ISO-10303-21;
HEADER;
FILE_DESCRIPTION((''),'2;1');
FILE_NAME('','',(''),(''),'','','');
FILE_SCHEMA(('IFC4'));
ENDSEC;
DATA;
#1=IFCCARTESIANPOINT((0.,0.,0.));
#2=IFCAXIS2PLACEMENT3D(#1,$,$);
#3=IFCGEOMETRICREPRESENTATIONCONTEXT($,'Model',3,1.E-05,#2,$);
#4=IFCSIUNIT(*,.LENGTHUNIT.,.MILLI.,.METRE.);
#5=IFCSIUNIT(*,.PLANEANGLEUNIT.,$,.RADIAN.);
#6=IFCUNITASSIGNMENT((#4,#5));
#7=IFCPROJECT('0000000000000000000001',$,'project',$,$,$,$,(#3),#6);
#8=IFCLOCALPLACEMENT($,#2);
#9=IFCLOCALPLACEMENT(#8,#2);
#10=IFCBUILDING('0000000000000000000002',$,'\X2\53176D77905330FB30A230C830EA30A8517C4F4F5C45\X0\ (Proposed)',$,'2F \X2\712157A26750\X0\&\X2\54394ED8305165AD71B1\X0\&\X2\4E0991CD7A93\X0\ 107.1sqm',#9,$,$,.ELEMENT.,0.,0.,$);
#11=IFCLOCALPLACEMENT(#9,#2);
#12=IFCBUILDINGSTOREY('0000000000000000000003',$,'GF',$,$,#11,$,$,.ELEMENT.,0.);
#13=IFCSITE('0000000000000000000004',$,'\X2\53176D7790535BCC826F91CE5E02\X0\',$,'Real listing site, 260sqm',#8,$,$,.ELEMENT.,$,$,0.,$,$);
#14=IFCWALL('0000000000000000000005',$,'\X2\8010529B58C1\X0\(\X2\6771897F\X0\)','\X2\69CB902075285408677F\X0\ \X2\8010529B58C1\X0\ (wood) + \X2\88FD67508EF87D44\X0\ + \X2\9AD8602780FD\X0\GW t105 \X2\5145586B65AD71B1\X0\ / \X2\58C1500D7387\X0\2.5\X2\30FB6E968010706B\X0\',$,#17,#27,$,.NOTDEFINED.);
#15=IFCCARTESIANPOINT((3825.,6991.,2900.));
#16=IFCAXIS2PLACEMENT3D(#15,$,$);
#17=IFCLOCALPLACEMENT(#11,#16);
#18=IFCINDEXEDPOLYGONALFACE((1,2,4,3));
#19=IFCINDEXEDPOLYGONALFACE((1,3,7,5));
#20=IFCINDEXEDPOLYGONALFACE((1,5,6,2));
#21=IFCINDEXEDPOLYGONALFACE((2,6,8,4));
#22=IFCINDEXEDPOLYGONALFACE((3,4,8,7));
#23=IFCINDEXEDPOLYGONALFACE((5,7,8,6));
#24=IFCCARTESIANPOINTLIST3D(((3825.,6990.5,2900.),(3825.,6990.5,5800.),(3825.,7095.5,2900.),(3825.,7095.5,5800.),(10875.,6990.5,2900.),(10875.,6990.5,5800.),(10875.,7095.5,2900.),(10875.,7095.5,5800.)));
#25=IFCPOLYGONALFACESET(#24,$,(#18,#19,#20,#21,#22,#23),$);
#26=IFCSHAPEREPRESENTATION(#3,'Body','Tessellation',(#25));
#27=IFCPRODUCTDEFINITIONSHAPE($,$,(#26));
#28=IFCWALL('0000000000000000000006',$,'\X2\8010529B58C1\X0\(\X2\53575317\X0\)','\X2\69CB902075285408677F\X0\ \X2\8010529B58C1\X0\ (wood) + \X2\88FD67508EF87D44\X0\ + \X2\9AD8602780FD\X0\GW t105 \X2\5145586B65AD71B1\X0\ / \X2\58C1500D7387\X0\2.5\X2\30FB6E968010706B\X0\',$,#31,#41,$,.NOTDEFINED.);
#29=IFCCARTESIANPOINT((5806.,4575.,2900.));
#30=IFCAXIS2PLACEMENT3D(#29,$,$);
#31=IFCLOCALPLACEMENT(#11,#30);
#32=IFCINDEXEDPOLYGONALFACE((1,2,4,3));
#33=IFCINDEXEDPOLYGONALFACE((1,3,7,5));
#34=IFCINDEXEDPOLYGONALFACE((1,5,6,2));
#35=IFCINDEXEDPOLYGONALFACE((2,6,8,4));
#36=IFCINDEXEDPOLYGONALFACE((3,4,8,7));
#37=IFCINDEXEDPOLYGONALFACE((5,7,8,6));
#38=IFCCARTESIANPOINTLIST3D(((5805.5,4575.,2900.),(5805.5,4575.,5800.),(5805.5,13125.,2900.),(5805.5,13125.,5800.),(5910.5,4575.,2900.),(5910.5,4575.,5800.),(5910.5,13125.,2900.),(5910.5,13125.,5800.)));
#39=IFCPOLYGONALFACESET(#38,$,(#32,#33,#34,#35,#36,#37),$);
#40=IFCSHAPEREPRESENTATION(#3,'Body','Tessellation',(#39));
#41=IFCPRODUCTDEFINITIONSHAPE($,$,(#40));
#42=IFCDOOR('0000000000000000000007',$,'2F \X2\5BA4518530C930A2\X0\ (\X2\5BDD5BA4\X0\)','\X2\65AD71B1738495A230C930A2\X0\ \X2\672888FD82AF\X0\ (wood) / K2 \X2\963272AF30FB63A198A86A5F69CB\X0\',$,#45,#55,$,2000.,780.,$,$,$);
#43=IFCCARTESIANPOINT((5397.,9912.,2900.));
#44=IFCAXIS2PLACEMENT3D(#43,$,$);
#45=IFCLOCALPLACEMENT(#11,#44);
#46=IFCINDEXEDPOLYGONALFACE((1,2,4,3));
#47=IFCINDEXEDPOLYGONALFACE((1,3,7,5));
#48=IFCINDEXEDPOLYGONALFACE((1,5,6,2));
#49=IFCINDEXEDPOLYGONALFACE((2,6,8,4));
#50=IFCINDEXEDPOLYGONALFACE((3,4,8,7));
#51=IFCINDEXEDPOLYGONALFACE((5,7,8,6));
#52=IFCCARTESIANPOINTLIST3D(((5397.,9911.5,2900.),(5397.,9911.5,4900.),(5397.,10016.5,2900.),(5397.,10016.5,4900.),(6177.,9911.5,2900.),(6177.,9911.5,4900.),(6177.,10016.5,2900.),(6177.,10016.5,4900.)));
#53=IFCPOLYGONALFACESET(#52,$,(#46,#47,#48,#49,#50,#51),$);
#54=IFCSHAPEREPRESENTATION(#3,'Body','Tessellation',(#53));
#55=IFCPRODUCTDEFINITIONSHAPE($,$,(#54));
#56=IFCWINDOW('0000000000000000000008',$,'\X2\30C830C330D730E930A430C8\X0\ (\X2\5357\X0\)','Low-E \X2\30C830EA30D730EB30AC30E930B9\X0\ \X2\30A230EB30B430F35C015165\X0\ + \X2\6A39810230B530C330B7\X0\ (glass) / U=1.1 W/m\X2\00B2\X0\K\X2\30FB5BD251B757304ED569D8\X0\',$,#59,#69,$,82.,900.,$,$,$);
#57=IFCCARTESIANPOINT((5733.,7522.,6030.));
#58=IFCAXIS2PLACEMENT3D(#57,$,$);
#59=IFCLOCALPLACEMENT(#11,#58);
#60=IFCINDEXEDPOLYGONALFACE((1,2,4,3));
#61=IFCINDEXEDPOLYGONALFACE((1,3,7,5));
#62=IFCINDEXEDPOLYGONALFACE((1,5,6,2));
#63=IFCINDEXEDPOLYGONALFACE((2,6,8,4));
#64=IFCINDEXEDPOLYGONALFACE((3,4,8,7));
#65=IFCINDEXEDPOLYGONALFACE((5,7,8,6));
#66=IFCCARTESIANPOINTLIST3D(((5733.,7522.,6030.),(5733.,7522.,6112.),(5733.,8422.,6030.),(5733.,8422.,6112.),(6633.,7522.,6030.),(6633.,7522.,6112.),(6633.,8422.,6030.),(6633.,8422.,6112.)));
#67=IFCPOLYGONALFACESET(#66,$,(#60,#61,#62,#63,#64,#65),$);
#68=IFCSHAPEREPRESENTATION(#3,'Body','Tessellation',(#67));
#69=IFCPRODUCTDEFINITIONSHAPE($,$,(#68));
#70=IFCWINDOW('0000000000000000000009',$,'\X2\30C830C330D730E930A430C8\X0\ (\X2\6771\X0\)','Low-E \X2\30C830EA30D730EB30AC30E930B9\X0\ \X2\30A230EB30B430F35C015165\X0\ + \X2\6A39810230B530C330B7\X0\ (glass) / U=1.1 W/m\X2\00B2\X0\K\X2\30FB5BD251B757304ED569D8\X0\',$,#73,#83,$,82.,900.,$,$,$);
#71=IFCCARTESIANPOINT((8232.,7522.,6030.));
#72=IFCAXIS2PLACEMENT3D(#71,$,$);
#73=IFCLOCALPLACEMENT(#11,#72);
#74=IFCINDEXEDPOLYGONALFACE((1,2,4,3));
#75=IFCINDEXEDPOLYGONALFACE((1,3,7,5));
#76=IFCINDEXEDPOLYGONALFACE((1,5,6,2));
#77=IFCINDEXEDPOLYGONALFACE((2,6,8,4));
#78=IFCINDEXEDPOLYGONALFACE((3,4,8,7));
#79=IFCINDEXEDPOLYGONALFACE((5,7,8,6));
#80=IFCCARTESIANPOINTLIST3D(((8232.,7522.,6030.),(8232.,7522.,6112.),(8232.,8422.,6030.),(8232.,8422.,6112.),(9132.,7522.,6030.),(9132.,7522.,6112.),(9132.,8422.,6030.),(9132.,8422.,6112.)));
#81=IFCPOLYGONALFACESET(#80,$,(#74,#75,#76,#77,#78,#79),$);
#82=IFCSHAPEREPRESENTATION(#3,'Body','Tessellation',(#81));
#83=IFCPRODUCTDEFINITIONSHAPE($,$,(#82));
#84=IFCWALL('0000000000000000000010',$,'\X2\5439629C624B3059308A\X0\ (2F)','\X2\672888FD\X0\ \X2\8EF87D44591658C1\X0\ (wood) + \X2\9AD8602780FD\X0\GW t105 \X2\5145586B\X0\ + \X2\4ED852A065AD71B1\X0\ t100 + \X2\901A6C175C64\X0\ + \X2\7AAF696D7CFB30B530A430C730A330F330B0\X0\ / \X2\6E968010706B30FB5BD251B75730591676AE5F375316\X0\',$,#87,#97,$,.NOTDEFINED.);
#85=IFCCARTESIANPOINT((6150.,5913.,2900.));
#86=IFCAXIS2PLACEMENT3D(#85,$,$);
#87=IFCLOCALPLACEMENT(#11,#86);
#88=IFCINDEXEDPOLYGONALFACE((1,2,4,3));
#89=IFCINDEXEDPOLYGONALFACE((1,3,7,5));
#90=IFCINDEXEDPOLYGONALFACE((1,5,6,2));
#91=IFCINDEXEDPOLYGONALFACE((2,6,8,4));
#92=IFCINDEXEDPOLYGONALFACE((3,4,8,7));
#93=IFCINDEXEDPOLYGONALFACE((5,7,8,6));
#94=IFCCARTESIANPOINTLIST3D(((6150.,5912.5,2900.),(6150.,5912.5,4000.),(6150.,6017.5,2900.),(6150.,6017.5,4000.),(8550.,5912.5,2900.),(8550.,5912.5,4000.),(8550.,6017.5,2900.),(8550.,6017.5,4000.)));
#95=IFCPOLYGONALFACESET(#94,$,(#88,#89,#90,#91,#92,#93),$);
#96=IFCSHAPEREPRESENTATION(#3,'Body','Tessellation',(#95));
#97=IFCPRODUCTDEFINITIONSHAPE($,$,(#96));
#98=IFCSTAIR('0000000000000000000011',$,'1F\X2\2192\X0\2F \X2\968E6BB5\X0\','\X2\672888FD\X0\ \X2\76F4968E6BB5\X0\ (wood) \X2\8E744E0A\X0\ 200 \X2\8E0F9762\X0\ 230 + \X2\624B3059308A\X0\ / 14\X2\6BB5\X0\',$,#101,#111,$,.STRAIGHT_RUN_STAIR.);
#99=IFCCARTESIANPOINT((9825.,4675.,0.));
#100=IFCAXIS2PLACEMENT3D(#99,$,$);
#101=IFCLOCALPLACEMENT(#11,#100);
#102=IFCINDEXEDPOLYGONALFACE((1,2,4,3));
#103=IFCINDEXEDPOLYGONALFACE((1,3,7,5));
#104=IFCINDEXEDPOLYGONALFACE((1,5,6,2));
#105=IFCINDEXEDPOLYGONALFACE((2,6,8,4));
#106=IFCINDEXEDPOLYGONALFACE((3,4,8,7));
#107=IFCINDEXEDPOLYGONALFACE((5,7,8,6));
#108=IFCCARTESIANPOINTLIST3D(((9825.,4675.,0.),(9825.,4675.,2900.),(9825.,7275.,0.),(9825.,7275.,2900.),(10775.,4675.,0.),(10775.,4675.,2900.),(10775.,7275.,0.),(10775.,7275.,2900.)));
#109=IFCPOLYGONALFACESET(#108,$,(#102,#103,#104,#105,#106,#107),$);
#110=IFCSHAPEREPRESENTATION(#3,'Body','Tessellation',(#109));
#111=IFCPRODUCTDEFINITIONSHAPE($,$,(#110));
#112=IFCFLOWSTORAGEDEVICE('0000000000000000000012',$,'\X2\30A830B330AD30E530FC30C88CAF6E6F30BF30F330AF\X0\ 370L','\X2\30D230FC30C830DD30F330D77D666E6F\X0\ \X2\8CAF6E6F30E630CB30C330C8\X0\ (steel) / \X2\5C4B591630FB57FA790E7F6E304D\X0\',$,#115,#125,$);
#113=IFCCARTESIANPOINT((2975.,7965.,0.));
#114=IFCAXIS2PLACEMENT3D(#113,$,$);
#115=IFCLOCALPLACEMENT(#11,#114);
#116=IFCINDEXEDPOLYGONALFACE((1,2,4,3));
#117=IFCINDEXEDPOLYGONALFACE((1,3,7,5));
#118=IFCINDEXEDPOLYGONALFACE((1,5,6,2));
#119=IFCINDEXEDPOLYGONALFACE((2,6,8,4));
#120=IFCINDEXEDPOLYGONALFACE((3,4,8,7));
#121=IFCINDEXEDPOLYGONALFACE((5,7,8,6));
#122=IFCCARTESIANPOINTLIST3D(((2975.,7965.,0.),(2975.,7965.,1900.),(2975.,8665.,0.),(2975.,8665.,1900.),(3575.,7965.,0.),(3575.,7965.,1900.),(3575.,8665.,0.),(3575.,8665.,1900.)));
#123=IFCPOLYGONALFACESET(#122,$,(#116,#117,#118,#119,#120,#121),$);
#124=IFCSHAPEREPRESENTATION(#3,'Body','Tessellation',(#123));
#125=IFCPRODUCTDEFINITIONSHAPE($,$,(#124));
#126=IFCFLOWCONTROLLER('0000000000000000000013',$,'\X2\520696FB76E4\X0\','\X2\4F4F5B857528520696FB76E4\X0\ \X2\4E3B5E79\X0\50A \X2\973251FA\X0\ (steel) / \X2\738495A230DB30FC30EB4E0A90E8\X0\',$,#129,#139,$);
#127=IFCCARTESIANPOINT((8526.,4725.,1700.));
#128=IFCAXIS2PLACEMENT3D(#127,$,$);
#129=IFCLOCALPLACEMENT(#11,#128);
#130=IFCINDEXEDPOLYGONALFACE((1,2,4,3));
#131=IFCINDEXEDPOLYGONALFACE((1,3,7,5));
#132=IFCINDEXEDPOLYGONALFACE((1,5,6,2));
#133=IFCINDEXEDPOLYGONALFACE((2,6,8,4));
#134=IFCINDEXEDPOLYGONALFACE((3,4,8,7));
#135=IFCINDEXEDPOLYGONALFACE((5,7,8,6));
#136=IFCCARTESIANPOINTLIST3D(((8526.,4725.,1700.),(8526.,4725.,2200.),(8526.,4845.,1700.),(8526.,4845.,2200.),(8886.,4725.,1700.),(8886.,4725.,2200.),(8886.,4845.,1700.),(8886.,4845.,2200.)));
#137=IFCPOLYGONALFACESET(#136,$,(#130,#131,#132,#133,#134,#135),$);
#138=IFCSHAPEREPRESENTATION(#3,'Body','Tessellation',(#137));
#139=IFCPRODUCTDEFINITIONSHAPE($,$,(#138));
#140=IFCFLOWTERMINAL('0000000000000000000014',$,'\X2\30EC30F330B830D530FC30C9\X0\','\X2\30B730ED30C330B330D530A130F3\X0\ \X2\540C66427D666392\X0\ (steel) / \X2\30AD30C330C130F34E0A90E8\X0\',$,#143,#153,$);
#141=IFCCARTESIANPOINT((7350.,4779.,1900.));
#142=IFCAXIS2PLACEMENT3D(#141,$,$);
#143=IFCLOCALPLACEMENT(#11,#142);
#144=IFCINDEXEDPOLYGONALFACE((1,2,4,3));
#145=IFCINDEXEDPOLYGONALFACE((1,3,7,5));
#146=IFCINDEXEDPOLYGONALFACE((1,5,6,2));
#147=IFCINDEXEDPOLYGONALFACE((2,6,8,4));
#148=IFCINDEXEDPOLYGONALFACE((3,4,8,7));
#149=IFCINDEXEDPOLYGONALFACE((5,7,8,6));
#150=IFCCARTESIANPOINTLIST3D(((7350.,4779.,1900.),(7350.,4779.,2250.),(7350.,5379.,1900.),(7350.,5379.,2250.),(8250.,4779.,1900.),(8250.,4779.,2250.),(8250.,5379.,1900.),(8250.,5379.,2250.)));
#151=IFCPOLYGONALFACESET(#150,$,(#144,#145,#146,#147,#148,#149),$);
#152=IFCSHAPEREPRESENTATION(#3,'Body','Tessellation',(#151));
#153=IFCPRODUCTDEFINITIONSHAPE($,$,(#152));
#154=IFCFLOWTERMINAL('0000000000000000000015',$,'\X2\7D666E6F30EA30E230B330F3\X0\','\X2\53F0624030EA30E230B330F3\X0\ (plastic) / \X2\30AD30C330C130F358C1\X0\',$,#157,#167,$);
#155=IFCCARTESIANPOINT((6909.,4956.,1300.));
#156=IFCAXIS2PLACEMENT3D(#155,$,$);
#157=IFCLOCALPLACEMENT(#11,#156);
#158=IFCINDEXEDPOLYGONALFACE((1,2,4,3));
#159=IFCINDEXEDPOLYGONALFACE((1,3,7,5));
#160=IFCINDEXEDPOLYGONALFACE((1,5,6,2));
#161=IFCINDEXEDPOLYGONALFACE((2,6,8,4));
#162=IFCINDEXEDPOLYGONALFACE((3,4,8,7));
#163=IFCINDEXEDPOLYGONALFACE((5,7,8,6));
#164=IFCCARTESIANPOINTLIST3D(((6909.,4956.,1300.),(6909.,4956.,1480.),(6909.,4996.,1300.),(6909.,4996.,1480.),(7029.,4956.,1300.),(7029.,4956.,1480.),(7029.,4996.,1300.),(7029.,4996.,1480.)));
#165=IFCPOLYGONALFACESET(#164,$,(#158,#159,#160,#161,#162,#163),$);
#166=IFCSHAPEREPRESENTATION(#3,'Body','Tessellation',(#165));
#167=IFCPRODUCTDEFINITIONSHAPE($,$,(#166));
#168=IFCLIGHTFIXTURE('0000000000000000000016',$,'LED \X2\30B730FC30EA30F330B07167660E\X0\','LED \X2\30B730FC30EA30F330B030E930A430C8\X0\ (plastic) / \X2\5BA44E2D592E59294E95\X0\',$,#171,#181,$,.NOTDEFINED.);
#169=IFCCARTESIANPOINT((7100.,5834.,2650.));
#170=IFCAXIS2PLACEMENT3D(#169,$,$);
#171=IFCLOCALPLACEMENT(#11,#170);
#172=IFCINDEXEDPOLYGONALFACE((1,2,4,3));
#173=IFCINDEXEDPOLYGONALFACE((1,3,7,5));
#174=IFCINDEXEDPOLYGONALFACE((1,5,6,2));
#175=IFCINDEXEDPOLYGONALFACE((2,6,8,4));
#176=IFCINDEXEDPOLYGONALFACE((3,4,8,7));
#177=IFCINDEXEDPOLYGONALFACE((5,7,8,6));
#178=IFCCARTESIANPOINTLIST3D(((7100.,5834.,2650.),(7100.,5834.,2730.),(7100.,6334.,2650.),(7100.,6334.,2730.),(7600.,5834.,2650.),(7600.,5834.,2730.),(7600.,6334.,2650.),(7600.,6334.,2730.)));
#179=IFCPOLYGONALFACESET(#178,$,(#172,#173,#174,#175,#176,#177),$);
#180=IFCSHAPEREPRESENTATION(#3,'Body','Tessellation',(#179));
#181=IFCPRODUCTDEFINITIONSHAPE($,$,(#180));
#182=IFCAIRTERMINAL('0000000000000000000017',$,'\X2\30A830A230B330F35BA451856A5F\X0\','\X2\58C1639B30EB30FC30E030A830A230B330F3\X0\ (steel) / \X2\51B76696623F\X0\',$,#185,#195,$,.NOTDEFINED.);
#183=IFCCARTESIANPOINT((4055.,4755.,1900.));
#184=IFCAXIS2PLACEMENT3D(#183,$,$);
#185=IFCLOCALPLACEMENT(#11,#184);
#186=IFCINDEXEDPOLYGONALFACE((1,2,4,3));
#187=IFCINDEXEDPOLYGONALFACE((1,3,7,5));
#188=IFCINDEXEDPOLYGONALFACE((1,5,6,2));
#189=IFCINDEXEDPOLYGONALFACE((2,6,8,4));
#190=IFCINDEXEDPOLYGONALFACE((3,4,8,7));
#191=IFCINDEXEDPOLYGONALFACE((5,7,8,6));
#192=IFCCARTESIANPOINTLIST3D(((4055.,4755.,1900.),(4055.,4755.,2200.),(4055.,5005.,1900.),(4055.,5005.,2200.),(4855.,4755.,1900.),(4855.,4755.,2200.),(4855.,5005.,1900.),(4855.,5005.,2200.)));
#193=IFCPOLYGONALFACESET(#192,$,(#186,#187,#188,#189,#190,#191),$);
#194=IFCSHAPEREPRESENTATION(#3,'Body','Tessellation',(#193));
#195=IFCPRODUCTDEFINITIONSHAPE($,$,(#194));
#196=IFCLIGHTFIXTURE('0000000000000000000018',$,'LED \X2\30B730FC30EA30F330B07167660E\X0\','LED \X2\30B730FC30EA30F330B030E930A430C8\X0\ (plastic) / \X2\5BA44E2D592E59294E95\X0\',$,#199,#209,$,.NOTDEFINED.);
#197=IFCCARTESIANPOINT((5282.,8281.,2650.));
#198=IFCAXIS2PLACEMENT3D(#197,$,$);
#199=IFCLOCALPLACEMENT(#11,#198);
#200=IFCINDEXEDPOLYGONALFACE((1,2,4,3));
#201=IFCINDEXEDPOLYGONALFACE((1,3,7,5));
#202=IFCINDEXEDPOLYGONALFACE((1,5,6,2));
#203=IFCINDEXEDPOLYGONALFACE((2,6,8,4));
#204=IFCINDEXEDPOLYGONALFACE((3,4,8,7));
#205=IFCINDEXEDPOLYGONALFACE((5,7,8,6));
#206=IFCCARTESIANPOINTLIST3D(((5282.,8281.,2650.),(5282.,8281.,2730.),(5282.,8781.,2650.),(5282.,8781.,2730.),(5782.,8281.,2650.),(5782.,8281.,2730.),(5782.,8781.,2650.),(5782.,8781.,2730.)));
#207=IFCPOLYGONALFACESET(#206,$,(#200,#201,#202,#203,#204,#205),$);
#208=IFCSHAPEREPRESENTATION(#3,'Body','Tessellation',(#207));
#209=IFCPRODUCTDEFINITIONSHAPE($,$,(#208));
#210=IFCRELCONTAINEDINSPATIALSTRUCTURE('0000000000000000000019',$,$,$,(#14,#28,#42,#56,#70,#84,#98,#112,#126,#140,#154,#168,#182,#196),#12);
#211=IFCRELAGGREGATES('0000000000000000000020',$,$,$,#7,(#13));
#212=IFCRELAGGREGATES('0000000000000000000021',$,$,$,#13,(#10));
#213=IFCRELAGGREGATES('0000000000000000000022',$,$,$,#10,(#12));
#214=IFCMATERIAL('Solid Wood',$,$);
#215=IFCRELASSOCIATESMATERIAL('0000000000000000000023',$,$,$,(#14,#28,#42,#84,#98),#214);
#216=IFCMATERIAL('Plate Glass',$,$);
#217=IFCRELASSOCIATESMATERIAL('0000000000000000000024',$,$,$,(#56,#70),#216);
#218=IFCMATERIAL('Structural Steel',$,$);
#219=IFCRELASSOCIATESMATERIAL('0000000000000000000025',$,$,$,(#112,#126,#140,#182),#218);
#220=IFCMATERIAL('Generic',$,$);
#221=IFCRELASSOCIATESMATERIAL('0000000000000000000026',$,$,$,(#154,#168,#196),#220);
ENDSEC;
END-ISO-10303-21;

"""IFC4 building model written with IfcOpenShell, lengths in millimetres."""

from ifc_helpers import new_model, si_unit, frame, frame_2d, origin, place, context, project, spatial, rectangle, extrude, material, element, fill, save


model = new_model("IFC4")

# Units and contexts
model_context = context("Model", 3, precision=1e-05, world=origin())
ifc_project = project(units=[si_unit("LENGTHUNIT", "METRE", prefix="MILLI"), si_unit("PLANEANGLEUNIT", "RADIAN")], contexts=[model_context])

# Site, building, storey
site_placement = place(None, origin())
site = spatial("IfcSite", under=ifc_project, at=site_placement, Name="北海道富良野市", ObjectType="Real listing site, 260sqm", CompositionType="ELEMENT", RefElevation=0.0)
building_placement = place(site_placement, origin())
building = spatial("IfcBuilding", under=site, at=building_placement, Name="北海道・アトリエ兼住居 (Proposed)", ObjectType="2F 無垢材&吹付け断熱&三重窓 107.1sqm", CompositionType="ELEMENT", ElevationOfRefHeight=0.0, ElevationOfTerrain=0.0)
storey_placement = place(building_placement, origin())
storey = spatial("IfcBuildingStorey", under=building, at=storey_placement, Name="GF", CompositionType="ELEMENT", Elevation=0.0)

# Shared definitions
ifc_material_1 = material(Name="Solid Wood")

# Wall
wall_1_placement = place(storey_placement, frame((3825.0, 6991.0, 2900.0)))
element("IfcWall", 1, at=wall_1_placement, inside=storey, material=ifc_material_1, Name="耐力壁(東西)", Description="構造用合板 耐力壁 (wood) + 製材軸組 + 高性能GW t105 充填断熱 / 壁倍率2.5・準耐火", PredefinedType="NOTDEFINED", context=model_context, shape_type="SweptSolid", body=[
    extrude(rectangle(XDim=7050.0, YDim=105.0, at=frame_2d((3525.0, 52.0))), frame((3825.0, 6991.0, 2900.0)), (0.0, 0.0, 1.0), 2900.0),
])

# Wall, opening, door
wall_2_placement = place(storey_placement, frame((5806.0, 4575.0, 2900.0)))
wall_2 = element("IfcWall", 2, at=wall_2_placement, inside=storey, material=ifc_material_1, Name="耐力壁(南北)", Description="構造用合板 耐力壁 (wood) + 製材軸組 + 高性能GW t105 充填断熱 / 壁倍率2.5・準耐火", PredefinedType="NOTDEFINED", context=model_context, shape_type="SweptSolid", body=[
    extrude(rectangle(XDim=105.0, YDim=8550.0, at=frame_2d((52.0, 4275.0))), frame((5806.0, 4575.0, 2900.0)), (0.0, 0.0, 1.0), 2900.0),
])
opening_placement = place(storey_placement, frame((5397.0, 9912.0, 2900.0)))
opening = element("IfcOpeningElement", 3, at=opening_placement, cuts=wall_2, PredefinedType="NOTDEFINED", context=model_context, shape_type="SweptSolid", body=[
    extrude(rectangle(XDim=780.0, YDim=105.0, at=frame_2d((390.0, 52.0))), frame((5397.0, 9912.0, 2900.0)), (0.0, 0.0, 1.0), 2000.0),
])
door_placement = place(storey_placement, frame((5397.0, 9912.0, 2900.0)))
door = element("IfcDoor", 4, at=door_placement, inside=storey, material=ifc_material_1, Name="2F 室内ドア (寝室)", Description="断熱玄関ドア 木製芯 (wood) / K2 防犯・採風機構", OverallHeight=2000.0, OverallWidth=780.0, context=model_context, shape_type="SweptSolid", body=[
    extrude(rectangle(XDim=780.0, YDim=105.0, at=frame_2d((390.0, 52.0))), frame((5397.0, 9912.0, 2900.0)), (0.0, 0.0, 1.0), 2000.0),
])
fill(opening, door)

# Windows
ifc_material_2 = material(Name="Plate Glass")
window_1_placement = place(storey_placement, frame((5733.0, 7522.0, 6030.0)))
element("IfcWindow", 5, at=window_1_placement, inside=storey, material=ifc_material_2, Name="トップライト (南)", Description="Low-E トリプルガラス アルゴン封入 + 樹脂サッシ (glass) / U=1.1 W/m²K・寒冷地仕様", OverallHeight=82.0, OverallWidth=900.0, context=model_context, shape_type="SweptSolid", body=[
    extrude(rectangle(XDim=900.0, YDim=900.0, at=frame_2d((450.0, 450.0))), frame((5733.0, 7522.0, 6030.0)), (0.0, 0.0, 1.0), 82.0),
])
window_2_placement = place(storey_placement, frame((8232.0, 7522.0, 6030.0)))
element("IfcWindow", 6, at=window_2_placement, inside=storey, material=ifc_material_2, Name="トップライト (東)", Description="Low-E トリプルガラス アルゴン封入 + 樹脂サッシ (glass) / U=1.1 W/m²K・寒冷地仕様", OverallHeight=82.0, OverallWidth=900.0, context=model_context, shape_type="SweptSolid", body=[
    extrude(rectangle(XDim=900.0, YDim=900.0, at=frame_2d((450.0, 450.0))), frame((8232.0, 7522.0, 6030.0)), (0.0, 0.0, 1.0), 82.0),
])

# Wall
wall_3_placement = place(storey_placement, frame((6150.0, 5913.0, 2900.0)))
element("IfcWall", 7, at=wall_3_placement, inside=storey, material=ifc_material_1, Name="吹抜手すり (2F)", Description="木製 軸組外壁 (wood) + 高性能GW t105 充填 + 付加断熱 t100 + 通気層 + 窯業系サイディング / 準耐火・寒冷地外皮強化", PredefinedType="NOTDEFINED", context=model_context, shape_type="SweptSolid", body=[
    extrude(rectangle(XDim=2400.0, YDim=105.0, at=frame_2d((1200.0, 52.0))), frame((6150.0, 5913.0, 2900.0)), (0.0, 0.0, 1.0), 1100.0),
])

# Stair
stair_placement = place(storey_placement, frame((9825.0, 4675.0, 0.0)))
element("IfcStair", 8, at=stair_placement, inside=storey, material=ifc_material_1, Name="1F→2F 階段", Description="木製 直階段 (wood) 蹴上 200 踏面 230 + 手すり / 14段", PredefinedType="STRAIGHT_RUN_STAIR", context=model_context, shape_type="SweptSolid", body=[
    extrude(rectangle(XDim=950.0, YDim=2600.0, at=frame_2d((475.0, 1300.0))), frame((9825.0, 4675.0, 0.0)), (0.0, 0.0, 1.0), 2900.0),
])

# Flow storage device
ifc_material_3 = material(Name="Structural Steel")
flow_storage_device_placement = place(storey_placement, frame((2975.0, 7965.0, 0.0)))
element("IfcFlowStorageDevice", 9, at=flow_storage_device_placement, inside=storey, material=ifc_material_3, Name="エコキュート貯湯タンク 370L", Description="ヒートポンプ給湯 貯湯ユニット (steel) / 屋外・基礎置き", context=model_context, shape_type="SweptSolid", body=[
    extrude(rectangle(XDim=600.0, YDim=700.0, at=frame_2d((300.0, 350.0))), frame((2975.0, 7965.0, 0.0)), (0.0, 0.0, 1.0), 1900.0),
])

# Flow controller
flow_controller_placement = place(storey_placement, frame((8526.0, 4725.0, 1700.0)))
element("IfcFlowController", 10, at=flow_controller_placement, inside=storey, material=ifc_material_3, Name="分電盤", Description="住宅用分電盤 主幹50A 露出 (steel) / 玄関ホール上部", context=model_context, shape_type="SweptSolid", body=[
    extrude(rectangle(XDim=360.0, YDim=120.0, at=frame_2d((180.0, 60.0))), frame((8526.0, 4725.0, 1700.0)), (0.0, 0.0, 1.0), 500.0),
])

# Flow terminals
flow_terminal_1_placement = place(storey_placement, frame((7350.0, 4779.0, 1900.0)))
element("IfcFlowTerminal", 11, at=flow_terminal_1_placement, inside=storey, material=ifc_material_3, Name="レンジフード", Description="シロッコファン 同時給排 (steel) / キッチン上部", context=model_context, shape_type="SweptSolid", body=[
    extrude(rectangle(XDim=900.0, YDim=600.0, at=frame_2d((450.0, 300.0))), frame((7350.0, 4779.0, 1900.0)), (0.0, 0.0, 1.0), 350.0),
])
ifc_material_4 = material(Name="Generic")
flow_terminal_2_placement = place(storey_placement, frame((6909.0, 4956.0, 1300.0)))
element("IfcFlowTerminal", 12, at=flow_terminal_2_placement, inside=storey, material=ifc_material_4, Name="給湯リモコン", Description="台所リモコン (plastic) / キッチン壁", context=model_context, shape_type="SweptSolid", body=[
    extrude(rectangle(XDim=120.0, YDim=40.0, at=frame_2d((60.0, 20.0))), frame((6909.0, 4956.0, 1300.0)), (0.0, 0.0, 1.0), 180.0),
])

# Light fixture
light_fixture_1_placement = place(storey_placement, frame((7100.0, 5834.0, 2650.0)))
element("IfcLightFixture", 13, at=light_fixture_1_placement, inside=storey, material=ifc_material_4, Name="LED シーリング照明", Description="LED シーリングライト (plastic) / 室中央天井", PredefinedType="NOTDEFINED", context=model_context, shape_type="SweptSolid", body=[
    extrude(rectangle(XDim=500.0, YDim=500.0, at=frame_2d((250.0, 250.0))), frame((7100.0, 5834.0, 2650.0)), (0.0, 0.0, 1.0), 80.0),
])

# Air terminal
air_terminal_1_placement = place(storey_placement, frame((4055.0, 4755.0, 1900.0)))
element("IfcAirTerminal", 14, at=air_terminal_1_placement, inside=storey, material=ifc_material_3, Name="エアコン室内機", Description="壁掛ルームエアコン (steel) / 冷暖房", PredefinedType="NOTDEFINED", context=model_context, shape_type="SweptSolid", body=[
    extrude(rectangle(XDim=800.0, YDim=250.0, at=frame_2d((400.0, 125.0))), frame((4055.0, 4755.0, 1900.0)), (0.0, 0.0, 1.0), 300.0),
])

# Light fixture
light_fixture_2_placement = place(storey_placement, frame((5282.0, 8281.0, 2650.0)))
element("IfcLightFixture", 15, at=light_fixture_2_placement, inside=storey, material=ifc_material_4, Name="LED シーリング照明", Description="LED シーリングライト (plastic) / 室中央天井", PredefinedType="NOTDEFINED", context=model_context, shape_type="SweptSolid", body=[
    extrude(rectangle(XDim=500.0, YDim=500.0, at=frame_2d((250.0, 250.0))), frame((5282.0, 8281.0, 2650.0)), (0.0, 0.0, 1.0), 80.0),
])

save(model, "model.ifc")
